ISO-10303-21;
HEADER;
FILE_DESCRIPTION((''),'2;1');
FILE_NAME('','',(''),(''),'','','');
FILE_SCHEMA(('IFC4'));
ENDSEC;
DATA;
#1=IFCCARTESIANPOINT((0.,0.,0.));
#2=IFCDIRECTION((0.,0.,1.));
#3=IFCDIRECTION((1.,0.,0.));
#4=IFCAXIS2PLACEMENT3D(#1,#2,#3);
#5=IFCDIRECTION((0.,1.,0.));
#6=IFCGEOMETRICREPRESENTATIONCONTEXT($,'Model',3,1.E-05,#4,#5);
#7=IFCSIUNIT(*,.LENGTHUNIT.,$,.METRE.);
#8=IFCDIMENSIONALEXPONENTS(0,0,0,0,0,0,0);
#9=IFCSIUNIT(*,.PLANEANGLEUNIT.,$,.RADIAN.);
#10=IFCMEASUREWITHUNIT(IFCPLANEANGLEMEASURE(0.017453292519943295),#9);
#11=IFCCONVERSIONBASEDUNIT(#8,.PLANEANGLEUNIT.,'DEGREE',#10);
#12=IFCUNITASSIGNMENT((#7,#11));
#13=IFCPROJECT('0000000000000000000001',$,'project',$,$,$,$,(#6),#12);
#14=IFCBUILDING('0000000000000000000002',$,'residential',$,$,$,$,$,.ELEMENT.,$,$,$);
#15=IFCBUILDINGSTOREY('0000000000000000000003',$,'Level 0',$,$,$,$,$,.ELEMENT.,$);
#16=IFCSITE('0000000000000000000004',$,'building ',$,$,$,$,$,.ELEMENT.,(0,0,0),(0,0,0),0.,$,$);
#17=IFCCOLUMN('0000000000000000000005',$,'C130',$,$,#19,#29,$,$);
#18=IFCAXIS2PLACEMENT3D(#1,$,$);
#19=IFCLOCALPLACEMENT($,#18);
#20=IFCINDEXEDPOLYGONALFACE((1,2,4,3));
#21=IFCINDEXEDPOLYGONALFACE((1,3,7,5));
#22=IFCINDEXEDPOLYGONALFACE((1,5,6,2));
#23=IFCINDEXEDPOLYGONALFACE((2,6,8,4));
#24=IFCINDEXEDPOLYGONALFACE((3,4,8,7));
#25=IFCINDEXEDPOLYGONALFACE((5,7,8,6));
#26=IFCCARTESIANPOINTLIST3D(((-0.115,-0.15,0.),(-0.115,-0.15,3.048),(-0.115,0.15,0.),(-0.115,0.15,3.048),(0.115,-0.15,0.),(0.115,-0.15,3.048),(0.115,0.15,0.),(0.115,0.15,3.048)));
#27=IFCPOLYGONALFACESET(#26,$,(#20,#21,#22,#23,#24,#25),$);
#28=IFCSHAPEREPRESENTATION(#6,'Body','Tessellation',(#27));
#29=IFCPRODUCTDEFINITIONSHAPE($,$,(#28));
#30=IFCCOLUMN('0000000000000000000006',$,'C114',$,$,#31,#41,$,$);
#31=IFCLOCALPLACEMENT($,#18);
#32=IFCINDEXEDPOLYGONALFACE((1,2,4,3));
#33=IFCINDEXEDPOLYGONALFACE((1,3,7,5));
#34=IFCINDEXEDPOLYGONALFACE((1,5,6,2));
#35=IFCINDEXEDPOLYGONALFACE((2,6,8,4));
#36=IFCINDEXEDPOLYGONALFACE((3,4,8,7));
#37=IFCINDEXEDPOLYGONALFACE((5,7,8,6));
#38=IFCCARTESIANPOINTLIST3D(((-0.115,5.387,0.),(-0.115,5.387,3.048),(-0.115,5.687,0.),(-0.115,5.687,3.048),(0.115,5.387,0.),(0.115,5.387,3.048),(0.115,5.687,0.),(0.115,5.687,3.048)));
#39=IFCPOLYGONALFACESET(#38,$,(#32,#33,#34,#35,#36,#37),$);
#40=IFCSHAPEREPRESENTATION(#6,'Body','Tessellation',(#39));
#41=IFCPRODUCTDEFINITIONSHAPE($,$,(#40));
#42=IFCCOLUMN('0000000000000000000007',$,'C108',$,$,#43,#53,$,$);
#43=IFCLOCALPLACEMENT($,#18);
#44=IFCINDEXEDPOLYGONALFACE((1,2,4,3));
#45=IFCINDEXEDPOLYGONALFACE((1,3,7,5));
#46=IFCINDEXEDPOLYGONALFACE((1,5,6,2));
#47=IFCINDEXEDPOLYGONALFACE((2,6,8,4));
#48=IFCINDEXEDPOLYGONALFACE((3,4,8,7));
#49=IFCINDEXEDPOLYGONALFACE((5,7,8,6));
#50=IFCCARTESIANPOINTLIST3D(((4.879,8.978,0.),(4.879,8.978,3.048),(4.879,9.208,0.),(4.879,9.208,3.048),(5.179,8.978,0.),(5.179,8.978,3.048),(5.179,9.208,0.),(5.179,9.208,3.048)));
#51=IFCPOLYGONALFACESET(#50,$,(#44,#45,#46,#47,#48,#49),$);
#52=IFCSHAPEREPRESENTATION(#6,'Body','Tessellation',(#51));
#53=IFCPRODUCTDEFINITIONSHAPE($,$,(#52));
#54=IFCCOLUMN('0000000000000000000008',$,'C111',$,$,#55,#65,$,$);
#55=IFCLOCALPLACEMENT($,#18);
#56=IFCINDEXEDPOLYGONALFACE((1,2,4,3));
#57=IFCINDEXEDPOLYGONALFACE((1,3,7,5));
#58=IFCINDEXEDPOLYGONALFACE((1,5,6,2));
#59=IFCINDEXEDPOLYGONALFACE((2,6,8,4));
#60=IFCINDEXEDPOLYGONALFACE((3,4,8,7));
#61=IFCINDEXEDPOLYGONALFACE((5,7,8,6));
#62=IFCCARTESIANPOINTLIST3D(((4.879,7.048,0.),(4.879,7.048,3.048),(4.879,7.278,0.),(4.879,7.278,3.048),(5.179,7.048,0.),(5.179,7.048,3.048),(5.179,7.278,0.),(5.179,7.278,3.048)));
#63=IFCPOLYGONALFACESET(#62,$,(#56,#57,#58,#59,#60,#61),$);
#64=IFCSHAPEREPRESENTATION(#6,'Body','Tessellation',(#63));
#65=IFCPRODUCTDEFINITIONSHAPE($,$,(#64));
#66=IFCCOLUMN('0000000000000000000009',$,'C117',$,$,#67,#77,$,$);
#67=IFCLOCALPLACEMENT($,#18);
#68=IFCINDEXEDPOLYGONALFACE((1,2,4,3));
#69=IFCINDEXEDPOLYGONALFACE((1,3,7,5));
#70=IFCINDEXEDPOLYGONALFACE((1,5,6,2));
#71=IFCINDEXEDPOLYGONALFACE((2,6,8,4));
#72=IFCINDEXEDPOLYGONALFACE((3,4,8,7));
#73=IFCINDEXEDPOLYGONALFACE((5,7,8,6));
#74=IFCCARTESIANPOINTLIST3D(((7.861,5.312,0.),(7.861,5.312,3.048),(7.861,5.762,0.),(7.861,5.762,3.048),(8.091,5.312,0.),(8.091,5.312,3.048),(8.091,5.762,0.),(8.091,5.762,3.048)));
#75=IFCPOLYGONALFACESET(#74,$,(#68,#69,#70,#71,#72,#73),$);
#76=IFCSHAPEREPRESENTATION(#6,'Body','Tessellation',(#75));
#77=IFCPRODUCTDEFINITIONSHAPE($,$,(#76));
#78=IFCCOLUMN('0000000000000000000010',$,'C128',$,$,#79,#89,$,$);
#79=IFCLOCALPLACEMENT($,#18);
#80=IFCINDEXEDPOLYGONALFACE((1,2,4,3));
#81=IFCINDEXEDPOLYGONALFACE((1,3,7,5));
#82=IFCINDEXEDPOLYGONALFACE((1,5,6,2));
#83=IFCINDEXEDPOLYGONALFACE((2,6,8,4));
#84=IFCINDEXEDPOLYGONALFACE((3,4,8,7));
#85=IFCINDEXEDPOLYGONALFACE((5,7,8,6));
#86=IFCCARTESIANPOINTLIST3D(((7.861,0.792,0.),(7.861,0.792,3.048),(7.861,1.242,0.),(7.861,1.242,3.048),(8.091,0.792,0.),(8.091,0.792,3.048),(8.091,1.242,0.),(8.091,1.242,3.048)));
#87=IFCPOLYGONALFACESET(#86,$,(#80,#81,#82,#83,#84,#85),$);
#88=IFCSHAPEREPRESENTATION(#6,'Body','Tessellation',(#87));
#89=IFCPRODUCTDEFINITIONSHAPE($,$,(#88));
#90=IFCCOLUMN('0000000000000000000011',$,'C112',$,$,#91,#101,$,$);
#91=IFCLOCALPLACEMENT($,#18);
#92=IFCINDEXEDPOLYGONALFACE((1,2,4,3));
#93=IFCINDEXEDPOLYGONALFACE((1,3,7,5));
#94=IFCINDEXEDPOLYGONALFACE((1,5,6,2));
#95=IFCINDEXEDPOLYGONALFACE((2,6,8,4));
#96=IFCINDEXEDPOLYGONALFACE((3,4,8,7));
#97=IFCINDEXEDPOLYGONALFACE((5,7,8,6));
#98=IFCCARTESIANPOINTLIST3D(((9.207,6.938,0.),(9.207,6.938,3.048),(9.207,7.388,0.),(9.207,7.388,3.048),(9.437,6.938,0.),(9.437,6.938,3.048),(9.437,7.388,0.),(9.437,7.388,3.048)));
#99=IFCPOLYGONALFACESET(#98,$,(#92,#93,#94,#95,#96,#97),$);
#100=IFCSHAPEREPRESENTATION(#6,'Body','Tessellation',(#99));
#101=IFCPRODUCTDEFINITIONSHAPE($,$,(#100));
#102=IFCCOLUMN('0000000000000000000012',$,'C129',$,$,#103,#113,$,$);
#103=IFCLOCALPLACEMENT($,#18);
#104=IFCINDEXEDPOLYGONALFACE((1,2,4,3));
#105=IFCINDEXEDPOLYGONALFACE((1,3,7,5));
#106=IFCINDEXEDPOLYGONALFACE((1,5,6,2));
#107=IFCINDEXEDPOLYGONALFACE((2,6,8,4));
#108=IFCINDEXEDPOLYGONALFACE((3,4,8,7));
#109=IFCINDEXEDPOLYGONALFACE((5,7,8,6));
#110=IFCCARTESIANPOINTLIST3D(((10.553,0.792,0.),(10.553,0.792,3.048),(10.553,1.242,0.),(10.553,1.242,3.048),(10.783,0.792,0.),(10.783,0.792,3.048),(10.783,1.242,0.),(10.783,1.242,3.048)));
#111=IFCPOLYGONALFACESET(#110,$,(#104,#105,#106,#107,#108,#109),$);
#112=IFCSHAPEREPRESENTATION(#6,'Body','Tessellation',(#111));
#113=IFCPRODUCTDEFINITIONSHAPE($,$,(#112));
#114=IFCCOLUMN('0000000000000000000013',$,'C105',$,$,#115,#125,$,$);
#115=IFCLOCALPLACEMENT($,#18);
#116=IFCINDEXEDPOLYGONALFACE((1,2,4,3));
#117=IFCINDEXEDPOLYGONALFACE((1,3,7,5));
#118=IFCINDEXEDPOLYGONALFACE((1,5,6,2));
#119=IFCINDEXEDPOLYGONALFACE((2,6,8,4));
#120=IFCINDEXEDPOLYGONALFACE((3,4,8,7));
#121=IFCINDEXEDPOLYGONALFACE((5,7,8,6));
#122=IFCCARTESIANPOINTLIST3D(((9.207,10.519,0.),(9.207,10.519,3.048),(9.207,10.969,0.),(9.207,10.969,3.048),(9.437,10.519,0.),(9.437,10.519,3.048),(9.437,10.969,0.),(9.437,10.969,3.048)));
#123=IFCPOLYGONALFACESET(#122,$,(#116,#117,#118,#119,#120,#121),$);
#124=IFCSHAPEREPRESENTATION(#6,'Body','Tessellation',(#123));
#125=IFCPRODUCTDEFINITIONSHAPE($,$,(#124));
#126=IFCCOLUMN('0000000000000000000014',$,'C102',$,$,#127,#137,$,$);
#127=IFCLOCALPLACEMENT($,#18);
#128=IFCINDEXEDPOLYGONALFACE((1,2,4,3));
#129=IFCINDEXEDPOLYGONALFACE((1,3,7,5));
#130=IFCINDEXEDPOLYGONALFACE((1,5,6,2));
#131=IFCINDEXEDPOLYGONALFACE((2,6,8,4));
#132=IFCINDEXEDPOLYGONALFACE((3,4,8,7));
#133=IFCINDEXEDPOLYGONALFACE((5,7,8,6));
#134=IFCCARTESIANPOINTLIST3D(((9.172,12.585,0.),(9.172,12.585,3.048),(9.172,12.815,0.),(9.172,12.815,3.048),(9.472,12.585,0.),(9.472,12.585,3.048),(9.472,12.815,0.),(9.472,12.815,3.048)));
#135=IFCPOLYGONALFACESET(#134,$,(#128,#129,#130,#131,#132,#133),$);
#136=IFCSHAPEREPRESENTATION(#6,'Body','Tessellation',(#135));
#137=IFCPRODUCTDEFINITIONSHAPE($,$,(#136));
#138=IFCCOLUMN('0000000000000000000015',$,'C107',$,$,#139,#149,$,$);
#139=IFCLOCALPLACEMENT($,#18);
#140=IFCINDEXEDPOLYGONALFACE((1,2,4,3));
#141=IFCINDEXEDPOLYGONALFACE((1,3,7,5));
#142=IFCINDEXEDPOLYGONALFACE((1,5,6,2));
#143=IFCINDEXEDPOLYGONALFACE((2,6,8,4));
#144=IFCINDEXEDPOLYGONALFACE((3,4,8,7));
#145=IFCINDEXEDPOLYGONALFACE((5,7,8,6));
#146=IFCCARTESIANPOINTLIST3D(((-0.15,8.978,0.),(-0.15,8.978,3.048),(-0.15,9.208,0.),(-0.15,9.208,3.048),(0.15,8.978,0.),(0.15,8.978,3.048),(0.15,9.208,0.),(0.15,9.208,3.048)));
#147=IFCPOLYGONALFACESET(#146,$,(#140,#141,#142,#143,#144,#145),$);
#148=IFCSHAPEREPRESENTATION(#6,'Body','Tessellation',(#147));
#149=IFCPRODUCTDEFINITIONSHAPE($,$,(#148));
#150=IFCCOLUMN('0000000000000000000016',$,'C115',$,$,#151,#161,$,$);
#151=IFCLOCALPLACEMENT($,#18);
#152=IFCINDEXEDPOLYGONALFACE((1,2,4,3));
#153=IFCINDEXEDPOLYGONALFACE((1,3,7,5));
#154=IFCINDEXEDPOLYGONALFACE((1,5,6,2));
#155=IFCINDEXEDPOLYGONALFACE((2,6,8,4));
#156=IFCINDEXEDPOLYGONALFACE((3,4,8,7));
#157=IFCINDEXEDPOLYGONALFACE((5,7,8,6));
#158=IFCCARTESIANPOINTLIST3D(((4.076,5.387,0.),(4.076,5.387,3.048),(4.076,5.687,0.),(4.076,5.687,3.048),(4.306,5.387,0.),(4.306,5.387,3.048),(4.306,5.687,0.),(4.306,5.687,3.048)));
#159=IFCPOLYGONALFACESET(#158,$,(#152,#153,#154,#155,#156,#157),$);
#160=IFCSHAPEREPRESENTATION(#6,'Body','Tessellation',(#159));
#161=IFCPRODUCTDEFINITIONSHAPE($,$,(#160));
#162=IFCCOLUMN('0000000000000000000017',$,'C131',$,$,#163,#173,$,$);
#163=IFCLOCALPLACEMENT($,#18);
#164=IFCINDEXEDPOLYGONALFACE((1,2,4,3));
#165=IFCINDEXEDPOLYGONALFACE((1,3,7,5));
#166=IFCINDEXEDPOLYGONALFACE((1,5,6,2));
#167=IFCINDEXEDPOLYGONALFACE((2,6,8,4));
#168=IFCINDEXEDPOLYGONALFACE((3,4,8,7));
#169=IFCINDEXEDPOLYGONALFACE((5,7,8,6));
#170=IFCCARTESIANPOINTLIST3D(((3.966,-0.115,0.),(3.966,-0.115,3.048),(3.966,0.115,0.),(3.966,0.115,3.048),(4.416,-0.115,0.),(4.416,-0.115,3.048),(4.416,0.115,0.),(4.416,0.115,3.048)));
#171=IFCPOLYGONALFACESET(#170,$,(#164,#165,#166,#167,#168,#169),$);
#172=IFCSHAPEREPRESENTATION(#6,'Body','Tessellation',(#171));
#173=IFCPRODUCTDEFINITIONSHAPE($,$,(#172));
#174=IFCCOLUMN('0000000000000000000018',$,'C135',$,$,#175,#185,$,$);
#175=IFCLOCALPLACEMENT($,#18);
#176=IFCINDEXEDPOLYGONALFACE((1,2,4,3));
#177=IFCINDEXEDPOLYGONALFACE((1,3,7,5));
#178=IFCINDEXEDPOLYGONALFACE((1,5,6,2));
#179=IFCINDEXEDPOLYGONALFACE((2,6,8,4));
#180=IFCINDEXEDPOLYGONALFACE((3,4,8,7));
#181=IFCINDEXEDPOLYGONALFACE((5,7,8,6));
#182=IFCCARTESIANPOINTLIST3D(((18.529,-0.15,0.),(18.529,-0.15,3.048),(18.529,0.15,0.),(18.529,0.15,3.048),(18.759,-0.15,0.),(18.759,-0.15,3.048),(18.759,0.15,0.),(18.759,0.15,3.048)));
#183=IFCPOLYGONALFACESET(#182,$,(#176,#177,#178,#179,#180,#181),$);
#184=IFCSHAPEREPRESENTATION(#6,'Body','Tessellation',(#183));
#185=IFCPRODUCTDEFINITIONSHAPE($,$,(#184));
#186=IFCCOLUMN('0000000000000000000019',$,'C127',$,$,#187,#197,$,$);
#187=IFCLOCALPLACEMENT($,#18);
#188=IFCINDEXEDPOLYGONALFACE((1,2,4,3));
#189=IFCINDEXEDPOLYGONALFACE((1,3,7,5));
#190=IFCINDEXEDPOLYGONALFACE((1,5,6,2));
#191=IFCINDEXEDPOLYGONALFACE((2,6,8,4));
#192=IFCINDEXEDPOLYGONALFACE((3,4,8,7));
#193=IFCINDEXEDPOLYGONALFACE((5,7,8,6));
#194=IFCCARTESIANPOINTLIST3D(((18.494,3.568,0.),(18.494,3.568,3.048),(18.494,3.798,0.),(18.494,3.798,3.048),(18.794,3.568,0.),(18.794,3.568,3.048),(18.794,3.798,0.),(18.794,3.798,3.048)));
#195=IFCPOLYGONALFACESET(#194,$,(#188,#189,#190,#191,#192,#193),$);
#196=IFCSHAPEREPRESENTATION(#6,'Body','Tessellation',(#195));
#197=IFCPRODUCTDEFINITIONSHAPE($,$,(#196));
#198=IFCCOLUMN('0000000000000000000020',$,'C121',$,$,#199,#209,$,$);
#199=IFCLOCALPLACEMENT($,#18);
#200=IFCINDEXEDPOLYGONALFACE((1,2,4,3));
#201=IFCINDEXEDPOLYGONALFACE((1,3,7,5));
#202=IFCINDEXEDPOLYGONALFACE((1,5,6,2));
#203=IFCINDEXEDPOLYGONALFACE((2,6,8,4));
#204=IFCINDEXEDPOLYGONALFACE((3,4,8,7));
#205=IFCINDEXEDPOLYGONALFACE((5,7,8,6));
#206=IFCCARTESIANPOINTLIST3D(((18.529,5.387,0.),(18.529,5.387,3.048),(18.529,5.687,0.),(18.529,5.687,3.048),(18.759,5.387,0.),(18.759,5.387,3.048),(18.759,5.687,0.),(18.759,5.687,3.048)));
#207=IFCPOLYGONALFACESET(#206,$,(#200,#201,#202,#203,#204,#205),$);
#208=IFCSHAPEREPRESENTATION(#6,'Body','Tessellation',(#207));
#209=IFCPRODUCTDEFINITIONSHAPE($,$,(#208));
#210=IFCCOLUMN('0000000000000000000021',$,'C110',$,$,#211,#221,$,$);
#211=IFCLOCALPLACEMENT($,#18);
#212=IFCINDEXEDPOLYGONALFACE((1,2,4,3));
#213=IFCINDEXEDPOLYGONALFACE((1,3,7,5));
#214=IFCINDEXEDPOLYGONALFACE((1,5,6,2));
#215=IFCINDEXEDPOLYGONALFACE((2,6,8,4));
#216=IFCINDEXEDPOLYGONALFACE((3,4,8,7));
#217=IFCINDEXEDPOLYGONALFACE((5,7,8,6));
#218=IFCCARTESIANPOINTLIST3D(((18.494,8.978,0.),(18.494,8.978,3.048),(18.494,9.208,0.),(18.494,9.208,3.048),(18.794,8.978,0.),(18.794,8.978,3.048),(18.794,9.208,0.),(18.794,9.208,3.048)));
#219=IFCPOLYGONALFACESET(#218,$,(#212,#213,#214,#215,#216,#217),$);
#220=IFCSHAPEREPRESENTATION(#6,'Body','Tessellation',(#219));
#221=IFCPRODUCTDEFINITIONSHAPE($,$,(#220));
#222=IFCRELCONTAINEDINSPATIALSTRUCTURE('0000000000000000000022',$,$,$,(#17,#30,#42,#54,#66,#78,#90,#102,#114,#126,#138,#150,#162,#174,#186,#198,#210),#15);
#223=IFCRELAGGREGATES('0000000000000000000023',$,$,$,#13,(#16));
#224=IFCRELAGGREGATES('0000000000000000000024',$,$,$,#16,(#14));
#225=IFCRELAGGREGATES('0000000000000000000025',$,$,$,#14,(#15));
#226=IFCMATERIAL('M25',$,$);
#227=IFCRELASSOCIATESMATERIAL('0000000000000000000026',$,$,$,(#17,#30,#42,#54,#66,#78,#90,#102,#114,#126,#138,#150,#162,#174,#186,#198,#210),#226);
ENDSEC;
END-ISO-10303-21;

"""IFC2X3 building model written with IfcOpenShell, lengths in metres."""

from ifc_helpers import new_model, entity, si_unit, converted_unit, direction, frame, frame_2d, origin_with_axes, place, context, project, spatial, rectangle, extrude, material, element, save


model = new_model("IFC2X3")

# Units and contexts
model_context = context("Model", 3, precision=1e-05, world=origin_with_axes(), true_north=direction((0.0, 1.0, 0.0)))
ifc_project = project(units=[si_unit("LENGTHUNIT", "METRE"), converted_unit("PLANEANGLEUNIT", "DEGREE", entity("IfcPlaneAngleMeasure", 0.017453292519943295), si_unit("PLANEANGLEUNIT", "RADIAN"), dimensions=[0, 0, 0, 0, 0, 0, 0])], contexts=[model_context])

# Site, building, storey
site = spatial("IfcSite", under=ifc_project, Name="building ", CompositionType="ELEMENT", RefLatitude=(0, 0, 0), RefLongitude=(0, 0, 0), RefElevation=0.0)
building = spatial("IfcBuilding", under=site, Name="residential", CompositionType="ELEMENT")
storey = spatial("IfcBuildingStorey", under=building, Name="Level 0", CompositionType="ELEMENT")

# Columns
ifc_material = material(Name="M25")
placement = place(None, origin_with_axes())
element("IfcColumn", 1, at=placement, inside=storey, material=ifc_material, Name="C130", context=model_context, shape_type="SweptSolid", body=[
    extrude(rectangle(XDim=0.23, YDim=0.3, at=frame_2d((0.0, 0.0), x_axis=(1.0, 0.0, 0.0))), frame((0.0, 0.0, 0.0), z_axis=(0.0, 0.0, 1.0), x_axis=(1.0, 0.0, 0.0)), (0.0, 0.0, 1.0), 3.048),
])
element("IfcColumn", 2, at=placement, inside=storey, material=ifc_material, Name="C114", context=model_context, shape_type="SweptSolid", body=[
    extrude(rectangle(XDim=0.23, YDim=0.3, at=frame_2d((0.0, 0.0), x_axis=(1.0, 0.0, 0.0))), frame((0.0, 5.537, 0.0), z_axis=(0.0, 0.0, 1.0), x_axis=(1.0, 0.0, 0.0)), (0.0, 0.0, 1.0), 3.048),
])
element("IfcColumn", 3, at=placement, inside=storey, material=ifc_material, Name="C108", context=model_context, shape_type="SweptSolid", body=[
    extrude(rectangle(XDim=0.3, YDim=0.23, at=frame_2d((0.0, 0.0), x_axis=(1.0, 0.0, 0.0))), frame((5.029, 9.093, 0.0), z_axis=(0.0, 0.0, 1.0), x_axis=(1.0, 0.0, 0.0)), (0.0, 0.0, 1.0), 3.048),
])
element("IfcColumn", 4, at=placement, inside=storey, material=ifc_material, Name="C111", context=model_context, shape_type="SweptSolid", body=[
    extrude(rectangle(XDim=0.3, YDim=0.23, at=frame_2d((0.0, 0.0), x_axis=(1.0, 0.0, 0.0))), frame((5.029, 7.163, 0.0), z_axis=(0.0, 0.0, 1.0), x_axis=(1.0, 0.0, 0.0)), (0.0, 0.0, 1.0), 3.048),
])
element("IfcColumn", 5, at=placement, inside=storey, material=ifc_material, Name="C117", context=model_context, shape_type="SweptSolid", body=[
    extrude(rectangle(XDim=0.23, YDim=0.45, at=frame_2d((0.0, 0.0), x_axis=(1.0, 0.0, 0.0))), frame((7.976, 5.537, 0.0), z_axis=(0.0, 0.0, 1.0), x_axis=(1.0, 0.0, 0.0)), (0.0, 0.0, 1.0), 3.048),
])
element("IfcColumn", 6, at=placement, inside=storey, material=ifc_material, Name="C128", context=model_context, shape_type="SweptSolid", body=[
    extrude(rectangle(XDim=0.23, YDim=0.45, at=frame_2d((0.0, 0.0), x_axis=(1.0, 0.0, 0.0))), frame((7.976, 1.017, 0.0), z_axis=(0.0, 0.0, 1.0), x_axis=(1.0, 0.0, 0.0)), (0.0, 0.0, 1.0), 3.048),
])
element("IfcColumn", 7, at=placement, inside=storey, material=ifc_material, Name="C112", context=model_context, shape_type="SweptSolid", body=[
    extrude(rectangle(XDim=0.23, YDim=0.45, at=frame_2d((0.0, 0.0), x_axis=(1.0, 0.0, 0.0))), frame((9.322, 7.163, 0.0), z_axis=(0.0, 0.0, 1.0), x_axis=(1.0, 0.0, 0.0)), (0.0, 0.0, 1.0), 3.048),
])
element("IfcColumn", 8, at=placement, inside=storey, material=ifc_material, Name="C129", context=model_context, shape_type="SweptSolid", body=[
    extrude(rectangle(XDim=0.23, YDim=0.45, at=frame_2d((0.0, 0.0), x_axis=(1.0, 0.0, 0.0))), frame((10.668, 1.017, 0.0), z_axis=(0.0, 0.0, 1.0), x_axis=(1.0, 0.0, 0.0)), (0.0, 0.0, 1.0), 3.048),
])
element("IfcColumn", 9, at=placement, inside=storey, material=ifc_material, Name="C105", context=model_context, shape_type="SweptSolid", body=[
    extrude(rectangle(XDim=0.23, YDim=0.45, at=frame_2d((0.0, 0.0), x_axis=(1.0, 0.0, 0.0))), frame((9.322, 10.744, 0.0), z_axis=(0.0, 0.0, 1.0), x_axis=(1.0, 0.0, 0.0)), (0.0, 0.0, 1.0), 3.048),
])
element("IfcColumn", 10, at=placement, inside=storey, material=ifc_material, Name="C102", context=model_context, shape_type="SweptSolid", body=[
    extrude(rectangle(XDim=0.3, YDim=0.23, at=frame_2d((0.0, 0.0), x_axis=(1.0, 0.0, 0.0))), frame((9.322, 12.7, 0.0), z_axis=(0.0, 0.0, 1.0), x_axis=(1.0, 0.0, 0.0)), (0.0, 0.0, 1.0), 3.048),
])
element("IfcColumn", 11, at=placement, inside=storey, material=ifc_material, Name="C107", context=model_context, shape_type="SweptSolid", body=[
    extrude(rectangle(XDim=0.3, YDim=0.23, at=frame_2d((0.0, 0.0), x_axis=(1.0, 0.0, 0.0))), frame((0.0, 9.093, 0.0), z_axis=(0.0, 0.0, 1.0), x_axis=(1.0, 0.0, 0.0)), (0.0, 0.0, 1.0), 3.048),
])
element("IfcColumn", 12, at=placement, inside=storey, material=ifc_material, Name="C115", context=model_context, shape_type="SweptSolid", body=[
    extrude(rectangle(XDim=0.23, YDim=0.3, at=frame_2d((0.0, 0.0), x_axis=(1.0, 0.0, 0.0))), frame((4.191, 5.537, 0.0), z_axis=(0.0, 0.0, 1.0), x_axis=(1.0, 0.0, 0.0)), (0.0, 0.0, 1.0), 3.048),
])
element("IfcColumn", 13, at=placement, inside=storey, material=ifc_material, Name="C131", context=model_context, shape_type="SweptSolid", body=[
    extrude(rectangle(XDim=0.45, YDim=0.23, at=frame_2d((0.0, 0.0), x_axis=(1.0, 0.0, 0.0))), frame((4.191, 0.0, 0.0), z_axis=(0.0, 0.0, 1.0), x_axis=(1.0, 0.0, 0.0)), (0.0, 0.0, 1.0), 3.048),
])
element("IfcColumn", 14, at=placement, inside=storey, material=ifc_material, Name="C135", context=model_context, shape_type="SweptSolid", body=[
    extrude(rectangle(XDim=0.23, YDim=0.3, at=frame_2d((0.0, 0.0), x_axis=(1.0, 0.0, 0.0))), frame((18.644, 0.0, 0.0), z_axis=(0.0, 0.0, 1.0), x_axis=(1.0, 0.0, 0.0)), (0.0, 0.0, 1.0), 3.048),
])
element("IfcColumn", 15, at=placement, inside=storey, material=ifc_material, Name="C127", context=model_context, shape_type="SweptSolid", body=[
    extrude(rectangle(XDim=0.3, YDim=0.23, at=frame_2d((0.0, 0.0), x_axis=(1.0, 0.0, 0.0))), frame((18.644, 3.683, 0.0), z_axis=(0.0, 0.0, 1.0), x_axis=(1.0, 0.0, 0.0)), (0.0, 0.0, 1.0), 3.048),
])
element("IfcColumn", 16, at=placement, inside=storey, material=ifc_material, Name="C121", context=model_context, shape_type="SweptSolid", body=[
    extrude(rectangle(XDim=0.23, YDim=0.3, at=frame_2d((0.0, 0.0), x_axis=(1.0, 0.0, 0.0))), frame((18.644, 5.537, 0.0), z_axis=(0.0, 0.0, 1.0), x_axis=(1.0, 0.0, 0.0)), (0.0, 0.0, 1.0), 3.048),
])
element("IfcColumn", 17, at=placement, inside=storey, material=ifc_material, Name="C110", context=model_context, shape_type="SweptSolid", body=[
    extrude(rectangle(XDim=0.3, YDim=0.23, at=frame_2d((0.0, 0.0), x_axis=(1.0, 0.0, 0.0))), frame((18.644, 9.093, 0.0), z_axis=(0.0, 0.0, 1.0), x_axis=(1.0, 0.0, 0.0)), (0.0, 0.0, 1.0), 3.048),
])

save(model, "model.ifc")
